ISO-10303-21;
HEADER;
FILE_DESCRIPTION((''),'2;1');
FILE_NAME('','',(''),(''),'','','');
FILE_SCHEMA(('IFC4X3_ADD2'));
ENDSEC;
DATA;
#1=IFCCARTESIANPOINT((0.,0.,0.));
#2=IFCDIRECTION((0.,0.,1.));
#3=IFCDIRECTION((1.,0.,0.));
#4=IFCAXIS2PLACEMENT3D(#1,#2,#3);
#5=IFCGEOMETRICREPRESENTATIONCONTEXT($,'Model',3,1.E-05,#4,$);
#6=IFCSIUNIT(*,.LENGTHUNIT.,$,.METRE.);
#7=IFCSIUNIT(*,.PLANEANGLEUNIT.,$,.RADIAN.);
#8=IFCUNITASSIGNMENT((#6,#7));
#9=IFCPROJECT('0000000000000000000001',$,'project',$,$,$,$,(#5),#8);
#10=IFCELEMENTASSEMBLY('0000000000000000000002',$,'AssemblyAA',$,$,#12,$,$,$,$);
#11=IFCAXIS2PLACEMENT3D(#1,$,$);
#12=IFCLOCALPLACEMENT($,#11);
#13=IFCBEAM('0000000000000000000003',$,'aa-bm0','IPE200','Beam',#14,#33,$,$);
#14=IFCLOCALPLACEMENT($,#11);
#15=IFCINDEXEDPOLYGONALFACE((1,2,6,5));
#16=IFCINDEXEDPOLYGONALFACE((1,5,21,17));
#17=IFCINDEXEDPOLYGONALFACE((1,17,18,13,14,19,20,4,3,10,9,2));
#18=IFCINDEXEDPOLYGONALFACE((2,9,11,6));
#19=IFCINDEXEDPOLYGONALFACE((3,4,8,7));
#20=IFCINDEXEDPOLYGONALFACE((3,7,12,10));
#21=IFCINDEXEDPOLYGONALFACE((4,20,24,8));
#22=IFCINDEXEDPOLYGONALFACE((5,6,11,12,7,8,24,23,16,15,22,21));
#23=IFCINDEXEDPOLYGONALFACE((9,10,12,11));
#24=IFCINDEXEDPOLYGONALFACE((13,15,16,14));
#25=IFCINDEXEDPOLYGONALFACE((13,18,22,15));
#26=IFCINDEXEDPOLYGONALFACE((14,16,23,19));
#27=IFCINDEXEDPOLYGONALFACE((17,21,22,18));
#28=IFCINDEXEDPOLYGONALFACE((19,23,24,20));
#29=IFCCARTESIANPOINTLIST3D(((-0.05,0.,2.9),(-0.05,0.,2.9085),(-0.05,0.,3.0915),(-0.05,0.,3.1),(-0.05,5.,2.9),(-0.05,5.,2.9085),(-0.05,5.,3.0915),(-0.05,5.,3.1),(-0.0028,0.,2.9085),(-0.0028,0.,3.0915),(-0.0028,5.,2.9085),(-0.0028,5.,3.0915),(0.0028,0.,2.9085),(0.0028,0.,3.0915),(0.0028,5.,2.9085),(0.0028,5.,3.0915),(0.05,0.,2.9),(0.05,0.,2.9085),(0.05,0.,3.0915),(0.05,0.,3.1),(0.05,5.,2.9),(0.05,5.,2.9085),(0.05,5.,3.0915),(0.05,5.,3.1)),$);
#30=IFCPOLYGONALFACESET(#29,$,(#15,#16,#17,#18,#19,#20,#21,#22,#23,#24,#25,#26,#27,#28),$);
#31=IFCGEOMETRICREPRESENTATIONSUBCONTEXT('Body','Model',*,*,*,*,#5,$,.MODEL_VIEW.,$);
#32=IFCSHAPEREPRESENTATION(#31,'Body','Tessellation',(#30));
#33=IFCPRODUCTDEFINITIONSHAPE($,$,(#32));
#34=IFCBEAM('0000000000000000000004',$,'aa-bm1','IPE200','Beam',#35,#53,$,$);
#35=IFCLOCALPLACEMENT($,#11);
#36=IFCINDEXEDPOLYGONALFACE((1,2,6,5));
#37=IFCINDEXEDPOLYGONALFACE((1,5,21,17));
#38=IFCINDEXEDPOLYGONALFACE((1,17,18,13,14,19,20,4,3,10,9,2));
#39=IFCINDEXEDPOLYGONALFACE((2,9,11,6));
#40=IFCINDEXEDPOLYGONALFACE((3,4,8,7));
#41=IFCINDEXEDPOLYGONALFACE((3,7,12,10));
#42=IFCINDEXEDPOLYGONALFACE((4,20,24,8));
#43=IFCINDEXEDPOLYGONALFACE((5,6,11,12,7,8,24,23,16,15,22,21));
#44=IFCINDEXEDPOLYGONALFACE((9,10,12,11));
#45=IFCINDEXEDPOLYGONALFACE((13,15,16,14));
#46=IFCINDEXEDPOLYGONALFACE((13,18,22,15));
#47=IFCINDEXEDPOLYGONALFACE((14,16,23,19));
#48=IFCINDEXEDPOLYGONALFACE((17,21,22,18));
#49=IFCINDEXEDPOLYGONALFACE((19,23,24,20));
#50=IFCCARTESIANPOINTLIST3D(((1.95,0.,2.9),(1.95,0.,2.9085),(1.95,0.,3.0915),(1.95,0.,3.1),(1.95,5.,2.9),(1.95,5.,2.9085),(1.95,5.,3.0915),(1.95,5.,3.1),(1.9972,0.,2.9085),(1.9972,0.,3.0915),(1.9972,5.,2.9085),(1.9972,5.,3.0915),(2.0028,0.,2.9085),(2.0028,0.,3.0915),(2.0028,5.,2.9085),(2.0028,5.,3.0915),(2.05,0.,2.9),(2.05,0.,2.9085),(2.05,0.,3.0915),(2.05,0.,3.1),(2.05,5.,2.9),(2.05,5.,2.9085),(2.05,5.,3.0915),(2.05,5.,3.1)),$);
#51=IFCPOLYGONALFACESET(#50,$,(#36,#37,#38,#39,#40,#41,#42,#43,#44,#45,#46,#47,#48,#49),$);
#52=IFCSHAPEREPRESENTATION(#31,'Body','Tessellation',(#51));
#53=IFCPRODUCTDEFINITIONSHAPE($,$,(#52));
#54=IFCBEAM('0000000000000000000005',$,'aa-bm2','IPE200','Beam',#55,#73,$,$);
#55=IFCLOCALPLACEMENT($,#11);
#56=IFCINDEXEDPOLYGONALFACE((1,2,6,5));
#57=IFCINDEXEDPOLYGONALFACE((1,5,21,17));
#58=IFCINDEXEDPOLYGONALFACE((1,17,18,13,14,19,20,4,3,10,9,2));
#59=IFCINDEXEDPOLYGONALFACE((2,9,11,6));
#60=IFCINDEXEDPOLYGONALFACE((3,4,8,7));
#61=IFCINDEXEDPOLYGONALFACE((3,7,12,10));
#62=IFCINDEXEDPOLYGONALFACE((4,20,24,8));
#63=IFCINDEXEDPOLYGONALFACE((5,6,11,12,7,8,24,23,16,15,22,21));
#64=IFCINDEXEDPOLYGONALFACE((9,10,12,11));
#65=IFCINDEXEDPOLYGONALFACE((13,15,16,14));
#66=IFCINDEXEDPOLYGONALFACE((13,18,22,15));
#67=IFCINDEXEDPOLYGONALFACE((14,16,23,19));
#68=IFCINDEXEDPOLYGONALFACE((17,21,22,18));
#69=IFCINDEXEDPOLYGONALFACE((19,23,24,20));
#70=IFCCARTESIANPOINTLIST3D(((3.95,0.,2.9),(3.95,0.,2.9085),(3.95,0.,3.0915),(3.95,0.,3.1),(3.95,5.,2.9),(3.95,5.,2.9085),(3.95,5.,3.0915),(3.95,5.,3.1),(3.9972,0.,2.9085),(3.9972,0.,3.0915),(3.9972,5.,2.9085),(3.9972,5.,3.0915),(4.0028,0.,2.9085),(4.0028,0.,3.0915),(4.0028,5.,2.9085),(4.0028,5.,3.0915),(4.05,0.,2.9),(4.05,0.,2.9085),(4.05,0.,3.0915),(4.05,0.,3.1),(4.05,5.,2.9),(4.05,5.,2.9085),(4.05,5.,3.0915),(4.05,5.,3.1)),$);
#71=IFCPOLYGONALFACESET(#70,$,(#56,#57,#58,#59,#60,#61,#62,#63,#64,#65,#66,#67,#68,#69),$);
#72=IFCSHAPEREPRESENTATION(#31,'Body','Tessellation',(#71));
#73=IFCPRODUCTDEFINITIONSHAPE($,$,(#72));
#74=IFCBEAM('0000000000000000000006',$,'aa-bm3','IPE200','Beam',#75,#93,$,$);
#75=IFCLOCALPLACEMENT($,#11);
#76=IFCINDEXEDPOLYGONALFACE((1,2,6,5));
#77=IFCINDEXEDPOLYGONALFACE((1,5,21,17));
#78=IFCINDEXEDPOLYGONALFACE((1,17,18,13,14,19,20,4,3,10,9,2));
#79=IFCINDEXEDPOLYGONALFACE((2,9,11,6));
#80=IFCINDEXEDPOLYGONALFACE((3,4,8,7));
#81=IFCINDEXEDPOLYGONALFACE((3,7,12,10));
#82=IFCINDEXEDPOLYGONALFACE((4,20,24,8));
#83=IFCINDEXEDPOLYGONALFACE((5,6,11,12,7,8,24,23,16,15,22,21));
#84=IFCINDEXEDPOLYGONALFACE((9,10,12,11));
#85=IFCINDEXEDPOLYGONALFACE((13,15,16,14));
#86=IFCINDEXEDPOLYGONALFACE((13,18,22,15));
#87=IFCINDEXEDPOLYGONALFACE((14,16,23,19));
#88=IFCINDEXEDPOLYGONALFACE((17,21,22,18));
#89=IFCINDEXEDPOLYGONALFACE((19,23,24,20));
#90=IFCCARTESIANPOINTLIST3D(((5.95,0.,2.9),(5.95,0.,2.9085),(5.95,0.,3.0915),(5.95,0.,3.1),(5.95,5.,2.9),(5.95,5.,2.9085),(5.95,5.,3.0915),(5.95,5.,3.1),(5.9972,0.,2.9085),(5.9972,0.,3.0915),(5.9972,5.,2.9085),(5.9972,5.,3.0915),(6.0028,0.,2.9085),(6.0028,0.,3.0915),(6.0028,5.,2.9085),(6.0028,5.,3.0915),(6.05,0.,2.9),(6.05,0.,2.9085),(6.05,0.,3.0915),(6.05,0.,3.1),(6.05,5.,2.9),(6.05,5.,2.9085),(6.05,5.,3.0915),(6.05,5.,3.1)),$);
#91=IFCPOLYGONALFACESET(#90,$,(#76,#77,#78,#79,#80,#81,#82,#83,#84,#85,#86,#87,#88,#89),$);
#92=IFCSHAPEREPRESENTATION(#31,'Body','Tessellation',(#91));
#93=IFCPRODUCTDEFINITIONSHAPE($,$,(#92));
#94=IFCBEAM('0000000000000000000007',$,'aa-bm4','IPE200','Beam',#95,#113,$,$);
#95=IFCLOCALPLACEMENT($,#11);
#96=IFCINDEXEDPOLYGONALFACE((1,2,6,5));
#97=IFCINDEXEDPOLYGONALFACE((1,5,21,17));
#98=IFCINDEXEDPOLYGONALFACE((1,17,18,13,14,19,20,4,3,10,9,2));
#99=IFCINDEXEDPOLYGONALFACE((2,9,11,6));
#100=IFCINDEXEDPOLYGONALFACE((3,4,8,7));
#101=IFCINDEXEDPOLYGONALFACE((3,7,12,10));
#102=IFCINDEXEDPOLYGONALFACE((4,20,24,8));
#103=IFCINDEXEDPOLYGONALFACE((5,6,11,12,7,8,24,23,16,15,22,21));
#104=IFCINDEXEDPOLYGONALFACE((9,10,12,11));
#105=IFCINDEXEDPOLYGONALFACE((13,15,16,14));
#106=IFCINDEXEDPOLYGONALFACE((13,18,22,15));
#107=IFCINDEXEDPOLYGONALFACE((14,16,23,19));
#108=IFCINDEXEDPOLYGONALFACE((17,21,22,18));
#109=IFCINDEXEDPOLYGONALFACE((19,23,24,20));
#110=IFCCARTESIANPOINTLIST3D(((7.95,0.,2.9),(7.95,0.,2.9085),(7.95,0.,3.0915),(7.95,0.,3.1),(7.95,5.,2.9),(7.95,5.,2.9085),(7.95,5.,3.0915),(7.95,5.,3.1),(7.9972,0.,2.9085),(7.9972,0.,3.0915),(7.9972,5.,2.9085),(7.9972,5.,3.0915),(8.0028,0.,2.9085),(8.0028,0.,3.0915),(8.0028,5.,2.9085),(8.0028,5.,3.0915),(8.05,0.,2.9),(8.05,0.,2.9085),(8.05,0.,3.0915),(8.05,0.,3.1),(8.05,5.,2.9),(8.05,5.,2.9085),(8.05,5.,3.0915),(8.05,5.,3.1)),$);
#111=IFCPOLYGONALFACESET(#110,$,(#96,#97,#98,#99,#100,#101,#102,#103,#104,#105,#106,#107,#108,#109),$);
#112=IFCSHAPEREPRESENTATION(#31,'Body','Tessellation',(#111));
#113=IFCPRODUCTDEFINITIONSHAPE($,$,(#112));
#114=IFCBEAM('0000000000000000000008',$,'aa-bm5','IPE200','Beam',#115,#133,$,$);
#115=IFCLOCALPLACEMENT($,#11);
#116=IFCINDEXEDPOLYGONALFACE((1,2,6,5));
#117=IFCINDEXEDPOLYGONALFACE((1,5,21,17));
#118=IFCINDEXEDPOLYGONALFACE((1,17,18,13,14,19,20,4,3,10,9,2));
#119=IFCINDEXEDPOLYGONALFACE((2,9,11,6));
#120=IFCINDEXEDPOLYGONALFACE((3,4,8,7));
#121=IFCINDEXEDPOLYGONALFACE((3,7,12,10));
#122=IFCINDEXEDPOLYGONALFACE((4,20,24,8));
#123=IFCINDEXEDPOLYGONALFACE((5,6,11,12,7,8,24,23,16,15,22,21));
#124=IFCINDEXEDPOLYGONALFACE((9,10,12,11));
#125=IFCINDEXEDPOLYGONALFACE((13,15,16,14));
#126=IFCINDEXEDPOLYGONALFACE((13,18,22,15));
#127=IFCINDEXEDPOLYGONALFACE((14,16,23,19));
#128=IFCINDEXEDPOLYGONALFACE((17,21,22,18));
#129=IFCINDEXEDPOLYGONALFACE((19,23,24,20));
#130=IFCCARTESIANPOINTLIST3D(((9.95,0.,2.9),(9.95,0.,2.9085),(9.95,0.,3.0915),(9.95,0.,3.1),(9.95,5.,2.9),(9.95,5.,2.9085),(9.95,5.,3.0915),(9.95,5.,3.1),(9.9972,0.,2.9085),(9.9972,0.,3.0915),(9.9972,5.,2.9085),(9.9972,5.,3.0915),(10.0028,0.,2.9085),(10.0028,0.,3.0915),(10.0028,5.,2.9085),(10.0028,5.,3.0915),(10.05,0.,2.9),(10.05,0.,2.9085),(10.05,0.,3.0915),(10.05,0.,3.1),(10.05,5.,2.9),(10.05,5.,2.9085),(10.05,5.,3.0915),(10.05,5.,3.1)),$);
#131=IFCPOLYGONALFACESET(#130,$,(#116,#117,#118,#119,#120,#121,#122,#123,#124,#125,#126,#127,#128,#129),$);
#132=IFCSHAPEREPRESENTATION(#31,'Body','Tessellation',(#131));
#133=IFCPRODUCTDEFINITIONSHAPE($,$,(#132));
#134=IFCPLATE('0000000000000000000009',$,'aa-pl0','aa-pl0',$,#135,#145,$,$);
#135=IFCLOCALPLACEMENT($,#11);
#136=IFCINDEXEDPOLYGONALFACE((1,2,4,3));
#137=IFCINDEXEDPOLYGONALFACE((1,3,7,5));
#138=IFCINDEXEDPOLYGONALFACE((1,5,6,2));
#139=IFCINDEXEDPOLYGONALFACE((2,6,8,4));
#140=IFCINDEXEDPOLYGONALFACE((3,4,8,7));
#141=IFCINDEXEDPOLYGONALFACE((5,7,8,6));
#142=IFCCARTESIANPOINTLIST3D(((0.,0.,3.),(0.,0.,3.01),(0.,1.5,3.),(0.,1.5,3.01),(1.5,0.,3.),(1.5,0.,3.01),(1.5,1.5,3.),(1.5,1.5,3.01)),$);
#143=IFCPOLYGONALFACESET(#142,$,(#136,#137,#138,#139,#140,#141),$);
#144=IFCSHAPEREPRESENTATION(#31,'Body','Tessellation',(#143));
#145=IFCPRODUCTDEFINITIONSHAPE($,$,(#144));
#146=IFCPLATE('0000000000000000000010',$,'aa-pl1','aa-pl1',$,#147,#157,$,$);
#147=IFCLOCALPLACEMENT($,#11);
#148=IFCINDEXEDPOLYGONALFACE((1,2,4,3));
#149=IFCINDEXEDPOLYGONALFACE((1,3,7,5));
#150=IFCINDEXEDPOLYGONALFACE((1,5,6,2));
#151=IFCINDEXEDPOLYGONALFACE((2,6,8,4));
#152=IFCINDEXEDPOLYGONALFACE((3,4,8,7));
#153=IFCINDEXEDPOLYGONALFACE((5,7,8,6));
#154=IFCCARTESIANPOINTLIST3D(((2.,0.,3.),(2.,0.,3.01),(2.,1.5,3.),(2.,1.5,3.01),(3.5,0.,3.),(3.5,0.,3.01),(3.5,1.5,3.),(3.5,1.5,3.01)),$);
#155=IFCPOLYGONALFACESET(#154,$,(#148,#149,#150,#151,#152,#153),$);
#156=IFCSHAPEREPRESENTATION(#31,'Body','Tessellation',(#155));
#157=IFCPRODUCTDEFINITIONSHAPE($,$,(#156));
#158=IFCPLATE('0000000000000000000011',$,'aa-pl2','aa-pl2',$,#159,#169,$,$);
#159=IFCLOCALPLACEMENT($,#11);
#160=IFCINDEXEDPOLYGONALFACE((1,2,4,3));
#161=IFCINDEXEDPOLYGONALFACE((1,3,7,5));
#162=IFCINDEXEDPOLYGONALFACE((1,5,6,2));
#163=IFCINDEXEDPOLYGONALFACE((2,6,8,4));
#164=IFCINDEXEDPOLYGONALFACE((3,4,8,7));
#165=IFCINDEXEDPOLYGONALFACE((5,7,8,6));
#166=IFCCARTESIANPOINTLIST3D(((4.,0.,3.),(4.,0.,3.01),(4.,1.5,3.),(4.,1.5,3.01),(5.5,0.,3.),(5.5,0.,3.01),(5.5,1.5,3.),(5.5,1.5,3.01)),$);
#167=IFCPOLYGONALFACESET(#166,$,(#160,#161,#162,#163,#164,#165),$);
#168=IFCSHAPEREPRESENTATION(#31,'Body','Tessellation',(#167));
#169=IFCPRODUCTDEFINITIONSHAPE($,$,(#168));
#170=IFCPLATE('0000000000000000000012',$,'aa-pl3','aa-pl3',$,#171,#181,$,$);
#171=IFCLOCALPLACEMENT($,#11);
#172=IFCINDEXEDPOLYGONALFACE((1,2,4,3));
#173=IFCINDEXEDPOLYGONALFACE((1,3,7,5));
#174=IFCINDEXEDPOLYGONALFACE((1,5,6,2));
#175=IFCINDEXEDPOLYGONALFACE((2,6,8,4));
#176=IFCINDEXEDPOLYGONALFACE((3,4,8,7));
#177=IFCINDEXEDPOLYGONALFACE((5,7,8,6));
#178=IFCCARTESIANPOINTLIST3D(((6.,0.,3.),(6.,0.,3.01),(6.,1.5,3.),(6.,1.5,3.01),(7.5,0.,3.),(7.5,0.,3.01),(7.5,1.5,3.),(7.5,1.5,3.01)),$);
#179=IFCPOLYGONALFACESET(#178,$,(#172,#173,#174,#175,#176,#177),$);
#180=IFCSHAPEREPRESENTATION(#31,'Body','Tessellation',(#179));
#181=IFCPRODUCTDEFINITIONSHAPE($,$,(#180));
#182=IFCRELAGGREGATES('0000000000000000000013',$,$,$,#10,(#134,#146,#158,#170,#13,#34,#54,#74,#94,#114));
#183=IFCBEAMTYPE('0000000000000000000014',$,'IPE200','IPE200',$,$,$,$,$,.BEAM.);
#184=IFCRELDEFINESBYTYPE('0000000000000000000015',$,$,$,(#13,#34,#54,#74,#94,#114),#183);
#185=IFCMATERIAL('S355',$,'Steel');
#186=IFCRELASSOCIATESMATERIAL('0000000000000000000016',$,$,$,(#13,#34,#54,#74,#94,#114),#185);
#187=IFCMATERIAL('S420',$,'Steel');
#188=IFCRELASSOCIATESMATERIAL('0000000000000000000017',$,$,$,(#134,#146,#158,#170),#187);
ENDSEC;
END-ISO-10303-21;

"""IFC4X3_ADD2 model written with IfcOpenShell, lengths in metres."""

from ifc_helpers import new_model, si_unit, frame, origin_with_axes, place, context, subcontext, project, line, indexed_curve, i_section, outline, extrude, material, material_profile, profile_set, profile_usage, type_object, element, aggregate, save


model = new_model("IFC4X3_ADD2")

# Units and contexts
model_context = context("Model", 3, precision=1e-05, world=origin_with_axes())
body_context = subcontext(model_context, "Body", "Model", "MODEL_VIEW")
ifc_project = project(units=[si_unit("LENGTHUNIT", "METRE"), si_unit("PLANEANGLEUNIT", "RADIAN")], contexts=[model_context])

# Element assembly, beams, plates
placement_1 = place(None, origin_with_axes())
placement_2 = place(placement_1, origin_with_axes())
assembly_placement = place(placement_2, origin_with_axes())
assembly = element("IfcElementAssembly", 1, at=assembly_placement, Name="AssemblyAA")
ifc_material_1 = material(Name="S355", Category="Steel")
ifc_material_profile_1 = material_profile(ifc_material_1, i_section(OverallWidth=0.1, OverallDepth=0.2, WebThickness=0.0056, FlangeThickness=0.0085), Name="IPE200", Category="LoadBearing")
ifc_profile_set_1 = profile_set([ifc_material_profile_1], Name="IPE200")
ifc_profile_usage_1 = profile_usage(ifc_profile_set_1, cardinal=5)
beam_type = type_object("IfcBeamType", Name="IPE200", Description="IPE200", PredefinedType="BEAM")
placement_3 = place(assembly_placement, origin_with_axes())
beam_1_placement = place(placement_3, origin_with_axes())
beam_1 = element("IfcBeam", 2, at=beam_1_placement, type_object=beam_type, material=ifc_profile_usage_1, Name="aa-bm0", Description="IPE200", ObjectType="Beam", context=body_context, shape_type="SolidModel", body=[
    extrude(i_section(OverallWidth=0.1, OverallDepth=0.2, WebThickness=0.0056, FlangeThickness=0.0085), frame((0.0, 0.0, 3.0), z_axis=(0.0, 1.0, 0.0), x_axis=(-1.0, 0.0, 0.0)), (0.0, 0.0, 1.0), 5.0),
])
ifc_material_profile_2 = material_profile(ifc_material_1, i_section(OverallWidth=0.1, OverallDepth=0.2, WebThickness=0.0056, FlangeThickness=0.0085), Name="IPE200", Category="LoadBearing")
ifc_profile_set_2 = profile_set([ifc_material_profile_2], Name="IPE200")
ifc_profile_usage_2 = profile_usage(ifc_profile_set_2, cardinal=5)
placement_4 = place(assembly_placement, origin_with_axes())
beam_2_placement = place(placement_4, origin_with_axes())
beam_2 = element("IfcBeam", 3, at=beam_2_placement, type_object=beam_type, material=ifc_profile_usage_2, Name="aa-bm1", Description="IPE200", ObjectType="Beam", context=body_context, shape_type="SolidModel", body=[
    extrude(i_section(OverallWidth=0.1, OverallDepth=0.2, WebThickness=0.0056, FlangeThickness=0.0085), frame((2.0, 0.0, 3.0), z_axis=(0.0, 1.0, 0.0), x_axis=(-1.0, 0.0, 0.0)), (0.0, 0.0, 1.0), 5.0),
])
ifc_material_profile_3 = material_profile(ifc_material_1, i_section(OverallWidth=0.1, OverallDepth=0.2, WebThickness=0.0056, FlangeThickness=0.0085), Name="IPE200", Category="LoadBearing")
ifc_profile_set_3 = profile_set([ifc_material_profile_3], Name="IPE200")
ifc_profile_usage_3 = profile_usage(ifc_profile_set_3, cardinal=5)
placement_5 = place(assembly_placement, origin_with_axes())
beam_3_placement = place(placement_5, origin_with_axes())
beam_3 = element("IfcBeam", 4, at=beam_3_placement, type_object=beam_type, material=ifc_profile_usage_3, Name="aa-bm2", Description="IPE200", ObjectType="Beam", context=body_context, shape_type="SolidModel", body=[
    extrude(i_section(OverallWidth=0.1, OverallDepth=0.2, WebThickness=0.0056, FlangeThickness=0.0085), frame((4.0, 0.0, 3.0), z_axis=(0.0, 1.0, 0.0), x_axis=(-1.0, 0.0, 0.0)), (0.0, 0.0, 1.0), 5.0),
])
ifc_material_profile_4 = material_profile(ifc_material_1, i_section(OverallWidth=0.1, OverallDepth=0.2, WebThickness=0.0056, FlangeThickness=0.0085), Name="IPE200", Category="LoadBearing")
ifc_profile_set_4 = profile_set([ifc_material_profile_4], Name="IPE200")
ifc_profile_usage_4 = profile_usage(ifc_profile_set_4, cardinal=5)
placement_6 = place(assembly_placement, origin_with_axes())
beam_4_placement = place(placement_6, origin_with_axes())
beam_4 = element("IfcBeam", 5, at=beam_4_placement, type_object=beam_type, material=ifc_profile_usage_4, Name="aa-bm3", Description="IPE200", ObjectType="Beam", context=body_context, shape_type="SolidModel", body=[
    extrude(i_section(OverallWidth=0.1, OverallDepth=0.2, WebThickness=0.0056, FlangeThickness=0.0085), frame((6.0, 0.0, 3.0), z_axis=(0.0, 1.0, 0.0), x_axis=(-1.0, 0.0, 0.0)), (0.0, 0.0, 1.0), 5.0),
])
ifc_material_profile_5 = material_profile(ifc_material_1, i_section(OverallWidth=0.1, OverallDepth=0.2, WebThickness=0.0056, FlangeThickness=0.0085), Name="IPE200", Category="LoadBearing")
ifc_profile_set_5 = profile_set([ifc_material_profile_5], Name="IPE200")
ifc_profile_usage_5 = profile_usage(ifc_profile_set_5, cardinal=5)
placement_7 = place(assembly_placement, origin_with_axes())
beam_5_placement = place(placement_7, origin_with_axes())
beam_5 = element("IfcBeam", 6, at=beam_5_placement, type_object=beam_type, material=ifc_profile_usage_5, Name="aa-bm4", Description="IPE200", ObjectType="Beam", context=body_context, shape_type="SolidModel", body=[
    extrude(i_section(OverallWidth=0.1, OverallDepth=0.2, WebThickness=0.0056, FlangeThickness=0.0085), frame((8.0, 0.0, 3.0), z_axis=(0.0, 1.0, 0.0), x_axis=(-1.0, 0.0, 0.0)), (0.0, 0.0, 1.0), 5.0),
])
ifc_material_profile_6 = material_profile(ifc_material_1, i_section(OverallWidth=0.1, OverallDepth=0.2, WebThickness=0.0056, FlangeThickness=0.0085), Name="IPE200", Category="LoadBearing")
ifc_profile_set_6 = profile_set([ifc_material_profile_6], Name="IPE200")
ifc_profile_usage_6 = profile_usage(ifc_profile_set_6, cardinal=5)
placement_8 = place(assembly_placement, origin_with_axes())
beam_6_placement = place(placement_8, origin_with_axes())
beam_6 = element("IfcBeam", 7, at=beam_6_placement, type_object=beam_type, material=ifc_profile_usage_6, Name="aa-bm5", Description="IPE200", ObjectType="Beam", context=body_context, shape_type="SolidModel", body=[
    extrude(i_section(OverallWidth=0.1, OverallDepth=0.2, WebThickness=0.0056, FlangeThickness=0.0085), frame((10.0, 0.0, 3.0), z_axis=(0.0, 1.0, 0.0), x_axis=(-1.0, 0.0, 0.0)), (0.0, 0.0, 1.0), 5.0),
])
ifc_material_2 = material(Name="S420", Category="Steel")
plate_1_placement = place(None, origin_with_axes())
plate_1 = element("IfcPlate", 8, at=plate_1_placement, material=ifc_material_2, Name="aa-pl0", Description="aa-pl0", context=body_context, shape_type="SolidModel", body=[
    extrude(outline(indexed_curve([(0.0, 0.0), (0.0, 1.5), (1.5, 0.0), (1.5, 1.5)], segments=[line(3, 1), line(1, 2), line(2, 4), line(4, 3)])), frame((0.0, 0.0, 3.0), z_axis=(0.0, 0.0, 1.0), x_axis=(1.0, 0.0, 0.0)), (0.0, 0.0, 1.0), 0.01),
])
plate_2_placement = place(None, origin_with_axes())
plate_2 = element("IfcPlate", 9, at=plate_2_placement, material=ifc_material_2, Name="aa-pl1", Description="aa-pl1", context=body_context, shape_type="SolidModel", body=[
    extrude(outline(indexed_curve([(2.0, 0.0), (2.0, 1.5), (3.5, 0.0), (3.5, 1.5)], segments=[line(3, 1), line(1, 2), line(2, 4), line(4, 3)])), frame((0.0, 0.0, 3.0), z_axis=(0.0, 0.0, 1.0), x_axis=(1.0, 0.0, 0.0)), (0.0, 0.0, 1.0), 0.01),
])
plate_3_placement = place(None, origin_with_axes())
plate_3 = element("IfcPlate", 10, at=plate_3_placement, material=ifc_material_2, Name="aa-pl2", Description="aa-pl2", context=body_context, shape_type="SolidModel", body=[
    extrude(outline(indexed_curve([(4.0, 0.0), (4.0, 1.5), (5.5, 0.0), (5.5, 1.5)], segments=[line(3, 1), line(1, 2), line(2, 4), line(4, 3)])), frame((0.0, 0.0, 3.0), z_axis=(0.0, 0.0, 1.0), x_axis=(1.0, 0.0, 0.0)), (0.0, 0.0, 1.0), 0.01),
])
plate_4_placement = place(None, origin_with_axes())
plate_4 = element("IfcPlate", 11, at=plate_4_placement, material=ifc_material_2, Name="aa-pl3", Description="aa-pl3", context=body_context, shape_type="SolidModel", body=[
    extrude(outline(indexed_curve([(6.0, 0.0), (6.0, 1.5), (7.5, 0.0), (7.5, 1.5)], segments=[line(3, 1), line(1, 2), line(2, 4), line(4, 3)])), frame((0.0, 0.0, 3.0), z_axis=(0.0, 0.0, 1.0), x_axis=(1.0, 0.0, 0.0)), (0.0, 0.0, 1.0), 0.01),
])
aggregate(assembly, [plate_1, plate_2, plate_3, plate_4, beam_1, beam_2, beam_3, beam_4, beam_5, beam_6])

save(model, "model.ifc")
